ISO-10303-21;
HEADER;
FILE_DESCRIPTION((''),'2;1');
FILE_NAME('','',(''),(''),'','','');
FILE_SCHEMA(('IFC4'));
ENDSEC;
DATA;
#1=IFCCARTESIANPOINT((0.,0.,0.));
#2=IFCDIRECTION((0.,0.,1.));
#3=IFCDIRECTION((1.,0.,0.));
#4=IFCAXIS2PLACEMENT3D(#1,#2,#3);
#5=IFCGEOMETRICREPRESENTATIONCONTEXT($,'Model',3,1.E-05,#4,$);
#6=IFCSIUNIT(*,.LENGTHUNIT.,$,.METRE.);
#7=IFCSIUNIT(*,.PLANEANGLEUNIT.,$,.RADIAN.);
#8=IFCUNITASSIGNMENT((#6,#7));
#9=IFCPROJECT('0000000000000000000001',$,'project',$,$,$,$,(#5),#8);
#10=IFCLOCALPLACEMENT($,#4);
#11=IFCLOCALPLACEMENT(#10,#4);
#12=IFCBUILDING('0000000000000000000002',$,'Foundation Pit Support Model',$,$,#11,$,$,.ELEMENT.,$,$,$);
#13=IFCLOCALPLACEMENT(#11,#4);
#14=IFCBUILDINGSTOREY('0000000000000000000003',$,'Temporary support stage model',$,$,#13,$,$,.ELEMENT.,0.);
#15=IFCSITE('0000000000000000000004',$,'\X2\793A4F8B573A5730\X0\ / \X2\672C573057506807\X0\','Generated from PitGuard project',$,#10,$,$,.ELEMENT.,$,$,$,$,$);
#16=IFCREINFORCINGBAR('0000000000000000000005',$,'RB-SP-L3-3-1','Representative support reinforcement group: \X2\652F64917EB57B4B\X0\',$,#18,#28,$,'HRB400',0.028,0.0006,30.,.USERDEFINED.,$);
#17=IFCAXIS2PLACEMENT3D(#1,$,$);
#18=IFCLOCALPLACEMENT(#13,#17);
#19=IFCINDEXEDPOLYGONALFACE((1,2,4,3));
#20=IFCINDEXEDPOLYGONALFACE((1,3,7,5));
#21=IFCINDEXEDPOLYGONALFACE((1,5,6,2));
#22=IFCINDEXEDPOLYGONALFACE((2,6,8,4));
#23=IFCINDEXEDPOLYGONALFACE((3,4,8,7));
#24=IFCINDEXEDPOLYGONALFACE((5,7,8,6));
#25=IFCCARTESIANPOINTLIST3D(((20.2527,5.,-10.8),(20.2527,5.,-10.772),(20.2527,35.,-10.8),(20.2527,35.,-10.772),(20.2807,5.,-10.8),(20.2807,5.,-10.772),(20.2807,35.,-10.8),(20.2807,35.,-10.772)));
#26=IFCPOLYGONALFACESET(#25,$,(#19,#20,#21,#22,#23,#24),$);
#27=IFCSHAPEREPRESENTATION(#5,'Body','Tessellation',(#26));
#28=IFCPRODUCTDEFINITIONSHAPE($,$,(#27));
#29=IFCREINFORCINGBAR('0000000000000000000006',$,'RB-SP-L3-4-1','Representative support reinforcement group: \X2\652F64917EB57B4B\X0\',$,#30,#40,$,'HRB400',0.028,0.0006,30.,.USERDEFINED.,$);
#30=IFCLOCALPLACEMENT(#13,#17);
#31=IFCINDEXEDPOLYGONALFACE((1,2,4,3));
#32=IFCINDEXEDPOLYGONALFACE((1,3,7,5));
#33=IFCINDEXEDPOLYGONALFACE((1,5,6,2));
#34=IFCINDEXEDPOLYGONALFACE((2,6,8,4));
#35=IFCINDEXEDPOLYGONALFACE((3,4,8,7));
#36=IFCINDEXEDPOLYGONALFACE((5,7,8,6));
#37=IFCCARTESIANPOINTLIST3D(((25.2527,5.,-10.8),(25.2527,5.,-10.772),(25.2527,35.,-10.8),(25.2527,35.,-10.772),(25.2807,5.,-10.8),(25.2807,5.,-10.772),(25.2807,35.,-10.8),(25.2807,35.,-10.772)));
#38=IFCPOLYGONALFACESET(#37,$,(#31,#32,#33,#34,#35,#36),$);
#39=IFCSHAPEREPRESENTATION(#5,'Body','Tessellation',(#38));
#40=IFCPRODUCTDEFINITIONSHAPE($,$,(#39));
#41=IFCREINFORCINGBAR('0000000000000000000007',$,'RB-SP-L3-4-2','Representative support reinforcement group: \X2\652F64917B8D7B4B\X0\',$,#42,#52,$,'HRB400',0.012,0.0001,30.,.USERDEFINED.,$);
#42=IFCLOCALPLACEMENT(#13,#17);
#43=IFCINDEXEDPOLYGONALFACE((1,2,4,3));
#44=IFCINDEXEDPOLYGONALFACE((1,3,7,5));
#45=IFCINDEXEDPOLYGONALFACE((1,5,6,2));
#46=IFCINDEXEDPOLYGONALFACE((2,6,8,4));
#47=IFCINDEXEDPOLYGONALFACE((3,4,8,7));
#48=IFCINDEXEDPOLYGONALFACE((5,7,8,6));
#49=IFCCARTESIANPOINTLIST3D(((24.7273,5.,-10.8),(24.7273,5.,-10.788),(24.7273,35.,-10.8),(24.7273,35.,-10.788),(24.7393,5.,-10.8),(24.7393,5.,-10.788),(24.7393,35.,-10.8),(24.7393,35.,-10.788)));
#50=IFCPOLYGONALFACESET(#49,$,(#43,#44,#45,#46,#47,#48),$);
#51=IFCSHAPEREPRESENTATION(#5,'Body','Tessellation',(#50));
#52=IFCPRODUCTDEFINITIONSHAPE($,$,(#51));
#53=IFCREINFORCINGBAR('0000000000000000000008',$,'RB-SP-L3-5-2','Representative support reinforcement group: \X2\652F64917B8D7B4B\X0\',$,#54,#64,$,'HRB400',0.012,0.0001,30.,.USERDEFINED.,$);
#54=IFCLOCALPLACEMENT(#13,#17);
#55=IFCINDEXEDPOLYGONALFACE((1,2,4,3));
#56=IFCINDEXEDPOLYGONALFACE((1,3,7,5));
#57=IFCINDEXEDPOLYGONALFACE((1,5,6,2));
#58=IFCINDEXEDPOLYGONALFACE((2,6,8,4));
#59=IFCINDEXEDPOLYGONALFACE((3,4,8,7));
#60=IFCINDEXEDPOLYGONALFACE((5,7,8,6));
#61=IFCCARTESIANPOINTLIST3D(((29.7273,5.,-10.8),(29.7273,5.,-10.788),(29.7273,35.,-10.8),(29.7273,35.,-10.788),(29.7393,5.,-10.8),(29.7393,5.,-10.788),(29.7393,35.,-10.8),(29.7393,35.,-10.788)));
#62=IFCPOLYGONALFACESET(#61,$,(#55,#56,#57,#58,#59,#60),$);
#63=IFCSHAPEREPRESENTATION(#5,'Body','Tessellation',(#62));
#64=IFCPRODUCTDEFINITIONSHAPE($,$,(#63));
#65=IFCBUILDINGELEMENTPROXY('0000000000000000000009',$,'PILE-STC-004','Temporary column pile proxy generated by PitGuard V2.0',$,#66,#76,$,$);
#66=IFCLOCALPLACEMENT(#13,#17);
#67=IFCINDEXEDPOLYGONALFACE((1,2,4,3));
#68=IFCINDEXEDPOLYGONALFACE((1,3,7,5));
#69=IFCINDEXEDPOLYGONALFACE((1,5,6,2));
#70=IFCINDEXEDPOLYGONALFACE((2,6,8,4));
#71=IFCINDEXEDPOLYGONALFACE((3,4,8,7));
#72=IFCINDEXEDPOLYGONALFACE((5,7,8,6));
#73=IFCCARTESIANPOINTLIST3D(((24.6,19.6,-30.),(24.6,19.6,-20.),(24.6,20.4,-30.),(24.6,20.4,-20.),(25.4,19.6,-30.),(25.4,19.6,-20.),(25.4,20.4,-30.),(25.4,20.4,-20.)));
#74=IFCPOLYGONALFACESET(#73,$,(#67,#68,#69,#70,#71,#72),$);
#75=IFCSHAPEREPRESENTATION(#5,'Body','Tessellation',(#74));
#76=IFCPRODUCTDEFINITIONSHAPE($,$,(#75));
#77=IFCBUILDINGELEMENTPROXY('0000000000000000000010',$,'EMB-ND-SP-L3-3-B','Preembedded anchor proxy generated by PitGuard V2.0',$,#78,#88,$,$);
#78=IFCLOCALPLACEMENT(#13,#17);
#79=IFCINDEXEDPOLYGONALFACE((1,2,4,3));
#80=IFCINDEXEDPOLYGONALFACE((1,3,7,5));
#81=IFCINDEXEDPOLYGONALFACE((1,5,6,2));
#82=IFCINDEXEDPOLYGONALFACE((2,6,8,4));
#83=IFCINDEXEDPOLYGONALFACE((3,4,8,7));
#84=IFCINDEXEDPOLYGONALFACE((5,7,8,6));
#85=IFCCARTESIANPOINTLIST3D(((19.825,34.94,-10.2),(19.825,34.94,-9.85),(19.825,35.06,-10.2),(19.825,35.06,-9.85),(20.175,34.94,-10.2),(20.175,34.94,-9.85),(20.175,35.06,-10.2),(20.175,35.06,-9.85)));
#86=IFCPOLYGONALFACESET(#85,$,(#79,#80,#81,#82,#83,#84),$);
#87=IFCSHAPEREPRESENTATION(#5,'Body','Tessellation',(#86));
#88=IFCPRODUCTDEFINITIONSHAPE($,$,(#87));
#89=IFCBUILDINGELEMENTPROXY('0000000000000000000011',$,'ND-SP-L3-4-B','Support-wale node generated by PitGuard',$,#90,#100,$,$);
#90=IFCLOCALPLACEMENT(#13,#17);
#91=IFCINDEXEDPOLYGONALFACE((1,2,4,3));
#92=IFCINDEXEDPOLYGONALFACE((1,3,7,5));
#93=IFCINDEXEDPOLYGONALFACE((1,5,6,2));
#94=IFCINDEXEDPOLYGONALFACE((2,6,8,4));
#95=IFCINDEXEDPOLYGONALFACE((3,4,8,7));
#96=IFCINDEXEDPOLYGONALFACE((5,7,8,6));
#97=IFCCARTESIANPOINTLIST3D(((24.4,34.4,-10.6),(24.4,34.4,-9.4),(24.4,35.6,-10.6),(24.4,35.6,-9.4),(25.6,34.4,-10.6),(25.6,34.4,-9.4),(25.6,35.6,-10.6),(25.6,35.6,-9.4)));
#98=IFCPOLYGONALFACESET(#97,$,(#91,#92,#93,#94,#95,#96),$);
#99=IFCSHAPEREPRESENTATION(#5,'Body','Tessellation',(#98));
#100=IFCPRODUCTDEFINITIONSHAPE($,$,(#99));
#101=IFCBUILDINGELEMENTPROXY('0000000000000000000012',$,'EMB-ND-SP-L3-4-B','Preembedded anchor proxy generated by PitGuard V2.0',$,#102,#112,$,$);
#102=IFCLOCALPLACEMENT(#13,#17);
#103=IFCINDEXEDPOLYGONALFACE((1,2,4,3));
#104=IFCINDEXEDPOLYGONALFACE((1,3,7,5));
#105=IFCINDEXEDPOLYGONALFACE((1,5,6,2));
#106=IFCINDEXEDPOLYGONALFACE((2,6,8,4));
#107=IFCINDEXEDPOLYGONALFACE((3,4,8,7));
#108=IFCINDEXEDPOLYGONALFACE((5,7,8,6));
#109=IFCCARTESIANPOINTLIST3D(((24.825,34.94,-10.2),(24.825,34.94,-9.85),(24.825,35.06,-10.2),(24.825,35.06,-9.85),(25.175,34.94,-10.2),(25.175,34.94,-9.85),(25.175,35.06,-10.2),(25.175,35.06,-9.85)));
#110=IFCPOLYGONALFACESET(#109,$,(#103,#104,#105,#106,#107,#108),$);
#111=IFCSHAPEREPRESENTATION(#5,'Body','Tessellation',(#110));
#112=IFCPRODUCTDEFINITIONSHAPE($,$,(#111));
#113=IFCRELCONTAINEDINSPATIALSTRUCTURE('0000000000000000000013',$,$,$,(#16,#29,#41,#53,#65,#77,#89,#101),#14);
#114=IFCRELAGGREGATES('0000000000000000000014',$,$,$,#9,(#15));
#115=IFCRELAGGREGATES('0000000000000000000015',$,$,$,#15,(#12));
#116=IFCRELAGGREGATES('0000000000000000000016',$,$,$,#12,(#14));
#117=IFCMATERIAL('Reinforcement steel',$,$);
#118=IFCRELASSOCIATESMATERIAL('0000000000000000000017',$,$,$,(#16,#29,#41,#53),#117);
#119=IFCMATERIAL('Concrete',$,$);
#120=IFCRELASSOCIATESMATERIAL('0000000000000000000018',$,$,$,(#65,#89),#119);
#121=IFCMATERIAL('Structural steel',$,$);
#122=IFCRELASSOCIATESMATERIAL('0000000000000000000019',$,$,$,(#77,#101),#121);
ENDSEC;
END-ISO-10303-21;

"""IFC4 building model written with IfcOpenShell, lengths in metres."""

from ifc_helpers import new_model, si_unit, frame, origin_with_axes, origin_2d, place, context, project, spatial, rectangle, extrude, material, element, save


model = new_model("IFC4")

# Units and contexts
model_context = context("Model", 3, precision=1e-05, world=origin_with_axes())
ifc_project = project(units=[si_unit("LENGTHUNIT", "METRE"), si_unit("PLANEANGLEUNIT", "RADIAN")], contexts=[model_context])

# Site, building, storey
site_placement = place(None, origin_with_axes())
site = spatial("IfcSite", under=ifc_project, at=site_placement, Name="示例场地 / 本地坐标", Description="Generated from PitGuard project", CompositionType="ELEMENT")
building_placement = place(site_placement, origin_with_axes())
building = spatial("IfcBuilding", under=site, at=building_placement, Name="Foundation Pit Support Model", CompositionType="ELEMENT")
storey_placement = place(building_placement, origin_with_axes())
storey = spatial("IfcBuildingStorey", under=building, at=storey_placement, Name="Temporary support stage model", CompositionType="ELEMENT", Elevation=0.0)

# Shared definitions
ifc_material_1 = material(Name="Structural steel")

# Shared definitions
ifc_material_2 = material(Name="Concrete")

# Reinforcing bars
ifc_material_3 = material(Name="Reinforcement steel")
for number, where, z_axis, x_axis, name in (
    (1, (20.2667, 20.0, -10.8), (0.0, 0.0, 1.0), (0.0, 1.0, 0.0), "RB-SP-L3-3-1"),
    (2, (25.2667, 20.0, -10.8), (0.0, 0.0, 1.0), (0.0, 1.0, 0.0), "RB-SP-L3-4-1"),
):
    element("IfcReinforcingBar", number, at=place(storey_placement, frame(where, z_axis=z_axis, x_axis=x_axis)), inside=storey, material=ifc_material_3, Name=name, Description="Representative support reinforcement group: 支撑纵筋", SteelGrade="HRB400", BarLength=30.0, CrossSectionArea=0.0006, NominalDiameter=0.028, PredefinedType="USERDEFINED", context=model_context, shape_type="SweptSolid", body=[
        extrude(rectangle(XDim=30.0, YDim=0.028, at=origin_2d()), origin_with_axes(), (0.0, 0.0, 1.0), 0.028),
    ])
for number, where, z_axis, x_axis, name in (
    (3, (24.7333, 20.0, -10.8), (0.0, 0.0, 1.0), (0.0, 1.0, 0.0), "RB-SP-L3-4-2"),
    (4, (29.7333, 20.0, -10.8), (0.0, 0.0, 1.0), (0.0, 1.0, 0.0), "RB-SP-L3-5-2"),
):
    element("IfcReinforcingBar", number, at=place(storey_placement, frame(where, z_axis=z_axis, x_axis=x_axis)), inside=storey, material=ifc_material_3, Name=name, Description="Representative support reinforcement group: 支撑箍筋", SteelGrade="HRB400", BarLength=30.0, CrossSectionArea=0.0001, NominalDiameter=0.012, PredefinedType="USERDEFINED", context=model_context, shape_type="SweptSolid", body=[
        extrude(rectangle(XDim=30.0, YDim=0.012, at=origin_2d()), origin_with_axes(), (0.0, 0.0, 1.0), 0.012),
    ])

# Building element proxies
proxy_1_placement = place(storey_placement, frame((25.0, 20.0, -30.0), z_axis=(0.0, 0.0, 1.0), x_axis=(1.0, 0.0, 0.0)))
element("IfcBuildingElementProxy", 5, at=proxy_1_placement, inside=storey, material=ifc_material_2, Name="PILE-STC-004", Description="Temporary column pile proxy generated by PitGuard V2.0", context=model_context, shape_type="SweptSolid", body=[
    extrude(rectangle(XDim=0.8, YDim=0.8, at=origin_2d()), origin_with_axes(), (0.0, 0.0, 1.0), 10.0),
])
proxy_2_placement = place(storey_placement, frame((20.0, 35.0, -10.2), z_axis=(0.0, 0.0, 1.0), x_axis=(1.0, 0.0, 0.0)))
element("IfcBuildingElementProxy", 6, at=proxy_2_placement, inside=storey, material=ifc_material_1, Name="EMB-ND-SP-L3-3-B", Description="Preembedded anchor proxy generated by PitGuard V2.0", context=model_context, shape_type="SweptSolid", body=[
    extrude(rectangle(XDim=0.35, YDim=0.12, at=origin_2d()), origin_with_axes(), (0.0, 0.0, 1.0), 0.35),
])
proxy_3_placement = place(storey_placement, frame((25.0, 35.0, -10.6), z_axis=(0.0, 0.0, 1.0), x_axis=(1.0, 0.0, 0.0)))
element("IfcBuildingElementProxy", 7, at=proxy_3_placement, inside=storey, material=ifc_material_2, Name="ND-SP-L3-4-B", Description="Support-wale node generated by PitGuard", context=model_context, shape_type="SweptSolid", body=[
    extrude(rectangle(XDim=1.2, YDim=1.2, at=origin_2d()), origin_with_axes(), (0.0, 0.0, 1.0), 1.2),
])
proxy_4_placement = place(storey_placement, frame((25.0, 35.0, -10.2), z_axis=(0.0, 0.0, 1.0), x_axis=(1.0, 0.0, 0.0)))
element("IfcBuildingElementProxy", 8, at=proxy_4_placement, inside=storey, material=ifc_material_1, Name="EMB-ND-SP-L3-4-B", Description="Preembedded anchor proxy generated by PitGuard V2.0", context=model_context, shape_type="SweptSolid", body=[
    extrude(rectangle(XDim=0.35, YDim=0.12, at=origin_2d()), origin_with_axes(), (0.0, 0.0, 1.0), 0.35),
])

save(model, "model.ifc")
